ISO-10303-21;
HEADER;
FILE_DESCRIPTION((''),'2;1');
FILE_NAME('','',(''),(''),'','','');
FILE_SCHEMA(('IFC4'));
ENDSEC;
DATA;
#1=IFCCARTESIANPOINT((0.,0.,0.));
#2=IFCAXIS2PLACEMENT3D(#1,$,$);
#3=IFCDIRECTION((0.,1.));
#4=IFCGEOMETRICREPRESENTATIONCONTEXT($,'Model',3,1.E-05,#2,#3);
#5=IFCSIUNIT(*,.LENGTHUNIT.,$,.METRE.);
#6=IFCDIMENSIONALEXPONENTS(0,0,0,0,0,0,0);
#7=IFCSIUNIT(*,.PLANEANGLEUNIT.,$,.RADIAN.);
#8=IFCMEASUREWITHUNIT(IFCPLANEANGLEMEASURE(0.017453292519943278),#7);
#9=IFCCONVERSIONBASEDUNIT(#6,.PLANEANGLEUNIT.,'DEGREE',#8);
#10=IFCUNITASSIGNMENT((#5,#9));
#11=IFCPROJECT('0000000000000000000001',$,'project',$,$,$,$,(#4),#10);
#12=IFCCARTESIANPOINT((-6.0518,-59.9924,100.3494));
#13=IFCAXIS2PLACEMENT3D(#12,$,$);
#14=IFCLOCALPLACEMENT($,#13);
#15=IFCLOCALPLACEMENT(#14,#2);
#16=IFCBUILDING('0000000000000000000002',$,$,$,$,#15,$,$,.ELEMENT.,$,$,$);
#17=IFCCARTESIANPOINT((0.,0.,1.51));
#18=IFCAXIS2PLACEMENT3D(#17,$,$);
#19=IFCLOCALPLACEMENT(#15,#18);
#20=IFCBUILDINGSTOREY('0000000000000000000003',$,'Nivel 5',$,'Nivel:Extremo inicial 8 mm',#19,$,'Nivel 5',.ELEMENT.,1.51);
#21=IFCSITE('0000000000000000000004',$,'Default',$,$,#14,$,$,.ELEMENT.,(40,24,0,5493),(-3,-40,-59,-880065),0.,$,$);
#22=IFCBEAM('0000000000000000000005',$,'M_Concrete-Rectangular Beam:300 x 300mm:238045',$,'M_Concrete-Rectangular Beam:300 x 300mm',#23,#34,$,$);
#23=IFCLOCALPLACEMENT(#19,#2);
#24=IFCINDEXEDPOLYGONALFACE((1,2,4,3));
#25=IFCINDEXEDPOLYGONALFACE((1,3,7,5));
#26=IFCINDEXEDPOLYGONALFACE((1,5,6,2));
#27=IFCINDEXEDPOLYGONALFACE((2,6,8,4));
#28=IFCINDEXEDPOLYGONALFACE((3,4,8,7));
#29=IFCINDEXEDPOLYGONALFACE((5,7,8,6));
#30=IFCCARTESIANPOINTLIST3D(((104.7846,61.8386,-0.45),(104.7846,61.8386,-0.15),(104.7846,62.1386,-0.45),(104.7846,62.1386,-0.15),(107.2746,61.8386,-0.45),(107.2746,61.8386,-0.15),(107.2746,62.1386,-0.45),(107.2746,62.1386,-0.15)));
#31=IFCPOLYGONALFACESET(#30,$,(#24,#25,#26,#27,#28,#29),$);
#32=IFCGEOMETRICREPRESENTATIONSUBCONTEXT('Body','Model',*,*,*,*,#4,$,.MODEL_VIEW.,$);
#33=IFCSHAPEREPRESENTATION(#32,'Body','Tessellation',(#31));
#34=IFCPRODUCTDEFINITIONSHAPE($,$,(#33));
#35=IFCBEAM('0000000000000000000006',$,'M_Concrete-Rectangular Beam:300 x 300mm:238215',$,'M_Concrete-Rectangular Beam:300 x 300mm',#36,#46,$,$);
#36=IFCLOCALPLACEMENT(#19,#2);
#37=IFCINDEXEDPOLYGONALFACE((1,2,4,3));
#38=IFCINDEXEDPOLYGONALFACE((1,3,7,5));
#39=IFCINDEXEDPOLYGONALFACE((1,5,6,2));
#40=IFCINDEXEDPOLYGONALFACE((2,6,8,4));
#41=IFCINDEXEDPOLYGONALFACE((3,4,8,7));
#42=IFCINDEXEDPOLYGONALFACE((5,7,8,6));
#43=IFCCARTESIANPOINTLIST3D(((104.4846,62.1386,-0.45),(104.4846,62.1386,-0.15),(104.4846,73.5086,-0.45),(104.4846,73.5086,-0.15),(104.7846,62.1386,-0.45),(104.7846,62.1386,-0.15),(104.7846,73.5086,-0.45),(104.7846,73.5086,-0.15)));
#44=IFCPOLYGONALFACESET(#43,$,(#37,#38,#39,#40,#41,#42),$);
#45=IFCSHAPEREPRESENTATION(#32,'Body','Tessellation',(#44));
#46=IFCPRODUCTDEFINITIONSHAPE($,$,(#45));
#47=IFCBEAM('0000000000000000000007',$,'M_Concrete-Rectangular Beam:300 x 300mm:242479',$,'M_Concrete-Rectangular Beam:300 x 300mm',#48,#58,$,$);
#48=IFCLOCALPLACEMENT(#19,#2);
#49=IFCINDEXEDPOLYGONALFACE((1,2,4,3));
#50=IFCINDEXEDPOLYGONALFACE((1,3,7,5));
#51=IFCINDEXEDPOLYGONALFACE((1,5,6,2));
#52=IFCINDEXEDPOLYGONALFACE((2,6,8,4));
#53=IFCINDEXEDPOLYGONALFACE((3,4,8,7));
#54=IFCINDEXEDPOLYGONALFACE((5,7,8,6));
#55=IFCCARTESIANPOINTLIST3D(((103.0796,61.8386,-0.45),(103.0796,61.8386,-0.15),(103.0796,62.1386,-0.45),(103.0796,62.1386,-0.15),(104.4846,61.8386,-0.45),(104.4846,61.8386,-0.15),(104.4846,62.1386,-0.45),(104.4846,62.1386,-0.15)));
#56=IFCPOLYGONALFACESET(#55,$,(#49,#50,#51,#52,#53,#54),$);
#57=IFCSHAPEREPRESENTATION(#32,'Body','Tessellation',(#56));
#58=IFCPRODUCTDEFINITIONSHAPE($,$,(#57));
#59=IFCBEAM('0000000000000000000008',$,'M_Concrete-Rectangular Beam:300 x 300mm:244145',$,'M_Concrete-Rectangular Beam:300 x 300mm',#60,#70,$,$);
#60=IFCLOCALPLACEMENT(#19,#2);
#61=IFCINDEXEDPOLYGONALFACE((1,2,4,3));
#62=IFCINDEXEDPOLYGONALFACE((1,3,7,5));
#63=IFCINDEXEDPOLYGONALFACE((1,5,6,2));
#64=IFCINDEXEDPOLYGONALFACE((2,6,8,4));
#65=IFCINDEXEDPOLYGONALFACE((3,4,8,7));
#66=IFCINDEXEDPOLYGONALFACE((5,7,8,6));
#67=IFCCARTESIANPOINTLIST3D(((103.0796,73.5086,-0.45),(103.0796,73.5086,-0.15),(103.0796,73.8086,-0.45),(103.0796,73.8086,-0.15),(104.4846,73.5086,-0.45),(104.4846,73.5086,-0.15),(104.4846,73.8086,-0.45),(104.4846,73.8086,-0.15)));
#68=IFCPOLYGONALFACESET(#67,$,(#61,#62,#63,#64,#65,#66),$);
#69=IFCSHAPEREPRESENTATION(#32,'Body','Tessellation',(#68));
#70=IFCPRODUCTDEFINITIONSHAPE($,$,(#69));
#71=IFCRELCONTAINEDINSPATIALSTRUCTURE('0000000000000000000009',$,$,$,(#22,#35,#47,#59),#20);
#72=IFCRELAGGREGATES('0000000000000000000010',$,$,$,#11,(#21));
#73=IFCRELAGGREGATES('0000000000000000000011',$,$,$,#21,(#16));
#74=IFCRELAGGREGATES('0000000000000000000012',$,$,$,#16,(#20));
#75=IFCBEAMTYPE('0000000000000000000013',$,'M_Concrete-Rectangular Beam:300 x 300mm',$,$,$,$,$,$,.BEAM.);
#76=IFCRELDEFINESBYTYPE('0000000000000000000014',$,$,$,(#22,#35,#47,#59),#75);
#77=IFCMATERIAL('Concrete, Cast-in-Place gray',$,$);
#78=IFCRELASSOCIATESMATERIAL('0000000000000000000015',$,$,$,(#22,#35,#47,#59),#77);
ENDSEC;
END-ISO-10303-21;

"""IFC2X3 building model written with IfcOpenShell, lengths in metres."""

from ifc_helpers import new_model, entity, si_unit, converted_unit, direction, frame, origin, origin_2d_with_axis, place, context, subcontext, project, spatial, rectangle, extrude, material, type_object, element, save


model = new_model("IFC2X3")

# Units and contexts
model_context = context("Model", 3, precision=1e-05, world=origin(), true_north=direction((0.0, 1.0)))
body_context = subcontext(model_context, "Body", "Model", "MODEL_VIEW")
ifc_project = project(units=[si_unit("LENGTHUNIT", "METRE"), converted_unit("PLANEANGLEUNIT", "DEGREE", entity("IfcPlaneAngleMeasure", 0.017453292519943278), si_unit("PLANEANGLEUNIT", "RADIAN"), dimensions=[0, 0, 0, 0, 0, 0, 0])], contexts=[model_context])

# Site, building, storey
site_placement = place(None, frame((-6.0518, -59.9924, 100.3494)))
site = spatial("IfcSite", under=ifc_project, at=site_placement, Name="Default", CompositionType="ELEMENT", RefLatitude=(40, 24, 0, 5493), RefLongitude=(-3, -40, -59, -880065), RefElevation=0.0)
building_placement = place(site_placement, origin())
building = spatial("IfcBuilding", under=site, at=building_placement, CompositionType="ELEMENT")
storey_placement = place(building_placement, frame((0.0, 0.0, 1.51)))
storey = spatial("IfcBuildingStorey", under=building, at=storey_placement, Name="Nivel 5", ObjectType="Nivel:Extremo inicial 8 mm", LongName="Nivel 5", CompositionType="ELEMENT", Elevation=1.51)

# Beams
ifc_material_1 = material(Name="Concrete, Cast-in-Place gray")
beam_type = type_object("IfcBeamType", Name="M_Concrete-Rectangular Beam:300 x 300mm", PredefinedType="BEAM")
beam_1_placement = place(storey_placement, frame((104.6346, 61.9886, 0.0)))
element("IfcBeam", 1, at=beam_1_placement, inside=storey, type_object=beam_type, material=ifc_material_1, Name="M_Concrete-Rectangular Beam:300 x 300mm:238045", ObjectType="M_Concrete-Rectangular Beam:300 x 300mm", context=body_context, shape_type="SweptSolid", body=[
    extrude(rectangle(XDim=0.3, YDim=0.3, at=origin_2d_with_axis()), frame((0.15, 0.0, -0.3), z_axis=(1.0, 0.0, 0.0), x_axis=(0.0, 0.0, -1.0)), (0.0, 0.0, 1.0), 2.49),
])
beam_2_placement = place(storey_placement, frame((104.6346, 73.6586, 0.0), z_axis=(0.0, 0.0, 1.0), x_axis=(0.0, -1.0, 0.0)))
element("IfcBeam", 2, at=beam_2_placement, inside=storey, type_object=beam_type, material=ifc_material_1, Name="M_Concrete-Rectangular Beam:300 x 300mm:238215", ObjectType="M_Concrete-Rectangular Beam:300 x 300mm", context=body_context, shape_type="SweptSolid", body=[
    extrude(rectangle(XDim=0.3, YDim=0.3, at=origin_2d_with_axis()), frame((0.15, 0.0, -0.3), z_axis=(1.0, 0.0, 0.0), x_axis=(0.0, 0.0, -1.0)), (0.0, 0.0, 1.0), 11.37),
])
beam_3_placement = place(storey_placement, frame((104.6346, 61.9886, 0.0), z_axis=(0.0, 0.0, 1.0), x_axis=(-1.0, 0.0, 0.0)))
element("IfcBeam", 3, at=beam_3_placement, inside=storey, type_object=beam_type, material=ifc_material_1, Name="M_Concrete-Rectangular Beam:300 x 300mm:242479", ObjectType="M_Concrete-Rectangular Beam:300 x 300mm", context=body_context, shape_type="SweptSolid", body=[
    extrude(rectangle(XDim=0.3, YDim=0.3, at=origin_2d_with_axis()), frame((0.15, 0.0, -0.3), z_axis=(1.0, 0.0, 0.0), x_axis=(0.0, 0.0, -1.0)), (0.0, 0.0, 1.0), 1.405),
])
beam_4_placement = place(storey_placement, frame((104.6346, 73.6586, 0.0), z_axis=(0.0, 0.0, 1.0), x_axis=(-1.0, 0.0, 0.0)))
element("IfcBeam", 4, at=beam_4_placement, inside=storey, type_object=beam_type, material=ifc_material_1, Name="M_Concrete-Rectangular Beam:300 x 300mm:244145", ObjectType="M_Concrete-Rectangular Beam:300 x 300mm", context=body_context, shape_type="SweptSolid", body=[
    extrude(rectangle(XDim=0.3, YDim=0.3, at=origin_2d_with_axis()), frame((0.15, 0.0, -0.3), z_axis=(1.0, 0.0, 0.0), x_axis=(0.0, 0.0, -1.0)), (0.0, 0.0, 1.0), 1.405),
])

save(model, "model.ifc")
